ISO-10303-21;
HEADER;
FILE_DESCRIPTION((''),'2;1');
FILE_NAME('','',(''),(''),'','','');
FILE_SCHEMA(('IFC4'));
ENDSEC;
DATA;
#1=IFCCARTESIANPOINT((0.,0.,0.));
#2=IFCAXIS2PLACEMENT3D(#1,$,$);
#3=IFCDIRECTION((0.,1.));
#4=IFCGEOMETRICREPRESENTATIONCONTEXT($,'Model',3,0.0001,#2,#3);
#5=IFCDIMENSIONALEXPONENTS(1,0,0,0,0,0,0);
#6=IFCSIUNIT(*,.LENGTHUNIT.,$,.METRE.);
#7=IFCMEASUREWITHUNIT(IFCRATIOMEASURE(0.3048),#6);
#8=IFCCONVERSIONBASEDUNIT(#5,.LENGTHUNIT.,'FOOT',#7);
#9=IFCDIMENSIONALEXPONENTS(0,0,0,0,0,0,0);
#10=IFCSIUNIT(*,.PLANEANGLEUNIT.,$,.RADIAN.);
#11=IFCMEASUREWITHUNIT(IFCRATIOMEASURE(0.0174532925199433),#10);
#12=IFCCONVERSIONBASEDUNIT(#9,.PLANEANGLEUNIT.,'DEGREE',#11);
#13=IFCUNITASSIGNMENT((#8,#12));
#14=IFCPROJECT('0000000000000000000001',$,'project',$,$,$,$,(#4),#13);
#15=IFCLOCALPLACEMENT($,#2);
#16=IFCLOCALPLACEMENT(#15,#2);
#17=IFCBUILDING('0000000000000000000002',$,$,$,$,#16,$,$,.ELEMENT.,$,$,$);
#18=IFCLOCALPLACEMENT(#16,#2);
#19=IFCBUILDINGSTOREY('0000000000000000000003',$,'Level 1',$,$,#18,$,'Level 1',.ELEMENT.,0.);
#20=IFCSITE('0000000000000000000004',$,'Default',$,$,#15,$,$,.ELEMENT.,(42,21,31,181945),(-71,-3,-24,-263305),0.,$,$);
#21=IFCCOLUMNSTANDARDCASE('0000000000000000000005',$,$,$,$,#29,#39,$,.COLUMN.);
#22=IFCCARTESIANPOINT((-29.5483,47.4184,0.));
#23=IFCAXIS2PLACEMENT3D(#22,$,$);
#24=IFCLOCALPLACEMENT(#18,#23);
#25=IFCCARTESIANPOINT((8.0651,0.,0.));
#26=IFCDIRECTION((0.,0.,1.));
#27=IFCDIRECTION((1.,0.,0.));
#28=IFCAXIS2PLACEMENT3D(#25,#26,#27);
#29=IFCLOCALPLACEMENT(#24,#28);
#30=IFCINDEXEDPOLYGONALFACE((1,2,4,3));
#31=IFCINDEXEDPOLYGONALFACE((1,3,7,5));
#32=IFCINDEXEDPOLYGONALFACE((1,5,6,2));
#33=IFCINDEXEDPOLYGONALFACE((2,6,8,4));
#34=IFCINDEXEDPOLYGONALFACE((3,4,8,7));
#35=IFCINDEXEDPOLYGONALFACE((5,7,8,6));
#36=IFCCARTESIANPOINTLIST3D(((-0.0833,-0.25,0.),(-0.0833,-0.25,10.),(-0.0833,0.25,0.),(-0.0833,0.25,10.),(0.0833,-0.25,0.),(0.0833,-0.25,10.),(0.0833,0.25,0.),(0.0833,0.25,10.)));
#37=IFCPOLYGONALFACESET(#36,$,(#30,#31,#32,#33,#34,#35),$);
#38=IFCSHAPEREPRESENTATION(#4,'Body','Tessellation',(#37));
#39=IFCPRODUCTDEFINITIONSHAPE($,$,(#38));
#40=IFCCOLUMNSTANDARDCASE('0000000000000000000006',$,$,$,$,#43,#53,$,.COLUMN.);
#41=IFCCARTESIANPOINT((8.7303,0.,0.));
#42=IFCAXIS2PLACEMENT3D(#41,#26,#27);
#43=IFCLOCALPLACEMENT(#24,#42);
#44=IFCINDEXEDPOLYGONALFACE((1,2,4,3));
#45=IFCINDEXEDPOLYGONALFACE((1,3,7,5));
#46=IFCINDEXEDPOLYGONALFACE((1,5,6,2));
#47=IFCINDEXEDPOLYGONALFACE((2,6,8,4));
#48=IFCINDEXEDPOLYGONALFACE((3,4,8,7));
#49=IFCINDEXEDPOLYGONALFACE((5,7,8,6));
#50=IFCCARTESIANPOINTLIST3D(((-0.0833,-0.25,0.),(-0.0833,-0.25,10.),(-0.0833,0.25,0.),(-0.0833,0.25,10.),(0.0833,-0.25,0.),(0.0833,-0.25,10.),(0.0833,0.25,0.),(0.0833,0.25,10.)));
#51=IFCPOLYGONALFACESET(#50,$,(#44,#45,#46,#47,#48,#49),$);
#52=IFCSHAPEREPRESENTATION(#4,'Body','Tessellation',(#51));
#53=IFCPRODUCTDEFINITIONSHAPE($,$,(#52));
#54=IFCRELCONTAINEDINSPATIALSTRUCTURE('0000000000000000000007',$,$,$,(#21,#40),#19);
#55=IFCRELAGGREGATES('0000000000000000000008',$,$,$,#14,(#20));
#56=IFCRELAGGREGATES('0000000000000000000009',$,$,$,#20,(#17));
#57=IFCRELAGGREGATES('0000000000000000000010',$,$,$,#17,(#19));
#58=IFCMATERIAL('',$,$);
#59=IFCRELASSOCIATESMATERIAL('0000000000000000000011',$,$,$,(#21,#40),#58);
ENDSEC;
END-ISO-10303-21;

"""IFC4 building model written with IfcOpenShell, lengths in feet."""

from ifc_helpers import new_model, entity, si_unit, converted_unit, direction, frame, origin, place, context, project, spatial, rectangle, extrude, material, element, save


model = new_model("IFC4")

# Units and contexts
model_context = context("Model", 3, precision=0.0001, world=origin(), true_north=direction((0.0, 1.0)))
ifc_project = project(units=[converted_unit("LENGTHUNIT", "FOOT", entity("IfcRatioMeasure", 0.3048), si_unit("LENGTHUNIT", "METRE"), dimensions=[1, 0, 0, 0, 0, 0, 0]), converted_unit("PLANEANGLEUNIT", "DEGREE", entity("IfcRatioMeasure", 0.0174532925199433), si_unit("PLANEANGLEUNIT", "RADIAN"), dimensions=[0, 0, 0, 0, 0, 0, 0])], contexts=[model_context])

# Site, building, storey
site_placement = place(None, origin())
site = spatial("IfcSite", under=ifc_project, at=site_placement, Name="Default", CompositionType="ELEMENT", RefLatitude=(42, 21, 31, 181945), RefLongitude=(-71, -3, -24, -263305), RefElevation=0.0)
building_placement = place(site_placement, origin())
building = spatial("IfcBuilding", under=site, at=building_placement, CompositionType="ELEMENT")
storey_placement = place(building_placement, origin())
storey = spatial("IfcBuildingStorey", under=building, at=storey_placement, Name="Level 1", LongName="Level 1", CompositionType="ELEMENT", Elevation=0.0)

# Columns
ifc_material_1 = material(Name="")
wall_1_placement = place(storey_placement, frame((-29.5483, 47.4184, 0.0)))
for number, where, z_axis, x_axis in (
    (1, (8.0651, 0.0, 0.0), (0.0, 0.0, 1.0), (1.0, 0.0, 0.0)),
    (2, (8.7303, 0.0, 0.0), (0.0, 0.0, 1.0), (1.0, 0.0, 0.0)),
):
    element("IfcColumnStandardCase", number, at=place(wall_1_placement, frame(where, z_axis=z_axis, x_axis=x_axis)), inside=storey, material=ifc_material_1, PredefinedType="COLUMN", context=model_context, shape_type="SweptSolid", body=[
        extrude(rectangle(XDim=0.1667, YDim=0.5), origin(), (0.0, 0.0, 1.0), 10.0),
    ])

save(model, "model.ifc")
